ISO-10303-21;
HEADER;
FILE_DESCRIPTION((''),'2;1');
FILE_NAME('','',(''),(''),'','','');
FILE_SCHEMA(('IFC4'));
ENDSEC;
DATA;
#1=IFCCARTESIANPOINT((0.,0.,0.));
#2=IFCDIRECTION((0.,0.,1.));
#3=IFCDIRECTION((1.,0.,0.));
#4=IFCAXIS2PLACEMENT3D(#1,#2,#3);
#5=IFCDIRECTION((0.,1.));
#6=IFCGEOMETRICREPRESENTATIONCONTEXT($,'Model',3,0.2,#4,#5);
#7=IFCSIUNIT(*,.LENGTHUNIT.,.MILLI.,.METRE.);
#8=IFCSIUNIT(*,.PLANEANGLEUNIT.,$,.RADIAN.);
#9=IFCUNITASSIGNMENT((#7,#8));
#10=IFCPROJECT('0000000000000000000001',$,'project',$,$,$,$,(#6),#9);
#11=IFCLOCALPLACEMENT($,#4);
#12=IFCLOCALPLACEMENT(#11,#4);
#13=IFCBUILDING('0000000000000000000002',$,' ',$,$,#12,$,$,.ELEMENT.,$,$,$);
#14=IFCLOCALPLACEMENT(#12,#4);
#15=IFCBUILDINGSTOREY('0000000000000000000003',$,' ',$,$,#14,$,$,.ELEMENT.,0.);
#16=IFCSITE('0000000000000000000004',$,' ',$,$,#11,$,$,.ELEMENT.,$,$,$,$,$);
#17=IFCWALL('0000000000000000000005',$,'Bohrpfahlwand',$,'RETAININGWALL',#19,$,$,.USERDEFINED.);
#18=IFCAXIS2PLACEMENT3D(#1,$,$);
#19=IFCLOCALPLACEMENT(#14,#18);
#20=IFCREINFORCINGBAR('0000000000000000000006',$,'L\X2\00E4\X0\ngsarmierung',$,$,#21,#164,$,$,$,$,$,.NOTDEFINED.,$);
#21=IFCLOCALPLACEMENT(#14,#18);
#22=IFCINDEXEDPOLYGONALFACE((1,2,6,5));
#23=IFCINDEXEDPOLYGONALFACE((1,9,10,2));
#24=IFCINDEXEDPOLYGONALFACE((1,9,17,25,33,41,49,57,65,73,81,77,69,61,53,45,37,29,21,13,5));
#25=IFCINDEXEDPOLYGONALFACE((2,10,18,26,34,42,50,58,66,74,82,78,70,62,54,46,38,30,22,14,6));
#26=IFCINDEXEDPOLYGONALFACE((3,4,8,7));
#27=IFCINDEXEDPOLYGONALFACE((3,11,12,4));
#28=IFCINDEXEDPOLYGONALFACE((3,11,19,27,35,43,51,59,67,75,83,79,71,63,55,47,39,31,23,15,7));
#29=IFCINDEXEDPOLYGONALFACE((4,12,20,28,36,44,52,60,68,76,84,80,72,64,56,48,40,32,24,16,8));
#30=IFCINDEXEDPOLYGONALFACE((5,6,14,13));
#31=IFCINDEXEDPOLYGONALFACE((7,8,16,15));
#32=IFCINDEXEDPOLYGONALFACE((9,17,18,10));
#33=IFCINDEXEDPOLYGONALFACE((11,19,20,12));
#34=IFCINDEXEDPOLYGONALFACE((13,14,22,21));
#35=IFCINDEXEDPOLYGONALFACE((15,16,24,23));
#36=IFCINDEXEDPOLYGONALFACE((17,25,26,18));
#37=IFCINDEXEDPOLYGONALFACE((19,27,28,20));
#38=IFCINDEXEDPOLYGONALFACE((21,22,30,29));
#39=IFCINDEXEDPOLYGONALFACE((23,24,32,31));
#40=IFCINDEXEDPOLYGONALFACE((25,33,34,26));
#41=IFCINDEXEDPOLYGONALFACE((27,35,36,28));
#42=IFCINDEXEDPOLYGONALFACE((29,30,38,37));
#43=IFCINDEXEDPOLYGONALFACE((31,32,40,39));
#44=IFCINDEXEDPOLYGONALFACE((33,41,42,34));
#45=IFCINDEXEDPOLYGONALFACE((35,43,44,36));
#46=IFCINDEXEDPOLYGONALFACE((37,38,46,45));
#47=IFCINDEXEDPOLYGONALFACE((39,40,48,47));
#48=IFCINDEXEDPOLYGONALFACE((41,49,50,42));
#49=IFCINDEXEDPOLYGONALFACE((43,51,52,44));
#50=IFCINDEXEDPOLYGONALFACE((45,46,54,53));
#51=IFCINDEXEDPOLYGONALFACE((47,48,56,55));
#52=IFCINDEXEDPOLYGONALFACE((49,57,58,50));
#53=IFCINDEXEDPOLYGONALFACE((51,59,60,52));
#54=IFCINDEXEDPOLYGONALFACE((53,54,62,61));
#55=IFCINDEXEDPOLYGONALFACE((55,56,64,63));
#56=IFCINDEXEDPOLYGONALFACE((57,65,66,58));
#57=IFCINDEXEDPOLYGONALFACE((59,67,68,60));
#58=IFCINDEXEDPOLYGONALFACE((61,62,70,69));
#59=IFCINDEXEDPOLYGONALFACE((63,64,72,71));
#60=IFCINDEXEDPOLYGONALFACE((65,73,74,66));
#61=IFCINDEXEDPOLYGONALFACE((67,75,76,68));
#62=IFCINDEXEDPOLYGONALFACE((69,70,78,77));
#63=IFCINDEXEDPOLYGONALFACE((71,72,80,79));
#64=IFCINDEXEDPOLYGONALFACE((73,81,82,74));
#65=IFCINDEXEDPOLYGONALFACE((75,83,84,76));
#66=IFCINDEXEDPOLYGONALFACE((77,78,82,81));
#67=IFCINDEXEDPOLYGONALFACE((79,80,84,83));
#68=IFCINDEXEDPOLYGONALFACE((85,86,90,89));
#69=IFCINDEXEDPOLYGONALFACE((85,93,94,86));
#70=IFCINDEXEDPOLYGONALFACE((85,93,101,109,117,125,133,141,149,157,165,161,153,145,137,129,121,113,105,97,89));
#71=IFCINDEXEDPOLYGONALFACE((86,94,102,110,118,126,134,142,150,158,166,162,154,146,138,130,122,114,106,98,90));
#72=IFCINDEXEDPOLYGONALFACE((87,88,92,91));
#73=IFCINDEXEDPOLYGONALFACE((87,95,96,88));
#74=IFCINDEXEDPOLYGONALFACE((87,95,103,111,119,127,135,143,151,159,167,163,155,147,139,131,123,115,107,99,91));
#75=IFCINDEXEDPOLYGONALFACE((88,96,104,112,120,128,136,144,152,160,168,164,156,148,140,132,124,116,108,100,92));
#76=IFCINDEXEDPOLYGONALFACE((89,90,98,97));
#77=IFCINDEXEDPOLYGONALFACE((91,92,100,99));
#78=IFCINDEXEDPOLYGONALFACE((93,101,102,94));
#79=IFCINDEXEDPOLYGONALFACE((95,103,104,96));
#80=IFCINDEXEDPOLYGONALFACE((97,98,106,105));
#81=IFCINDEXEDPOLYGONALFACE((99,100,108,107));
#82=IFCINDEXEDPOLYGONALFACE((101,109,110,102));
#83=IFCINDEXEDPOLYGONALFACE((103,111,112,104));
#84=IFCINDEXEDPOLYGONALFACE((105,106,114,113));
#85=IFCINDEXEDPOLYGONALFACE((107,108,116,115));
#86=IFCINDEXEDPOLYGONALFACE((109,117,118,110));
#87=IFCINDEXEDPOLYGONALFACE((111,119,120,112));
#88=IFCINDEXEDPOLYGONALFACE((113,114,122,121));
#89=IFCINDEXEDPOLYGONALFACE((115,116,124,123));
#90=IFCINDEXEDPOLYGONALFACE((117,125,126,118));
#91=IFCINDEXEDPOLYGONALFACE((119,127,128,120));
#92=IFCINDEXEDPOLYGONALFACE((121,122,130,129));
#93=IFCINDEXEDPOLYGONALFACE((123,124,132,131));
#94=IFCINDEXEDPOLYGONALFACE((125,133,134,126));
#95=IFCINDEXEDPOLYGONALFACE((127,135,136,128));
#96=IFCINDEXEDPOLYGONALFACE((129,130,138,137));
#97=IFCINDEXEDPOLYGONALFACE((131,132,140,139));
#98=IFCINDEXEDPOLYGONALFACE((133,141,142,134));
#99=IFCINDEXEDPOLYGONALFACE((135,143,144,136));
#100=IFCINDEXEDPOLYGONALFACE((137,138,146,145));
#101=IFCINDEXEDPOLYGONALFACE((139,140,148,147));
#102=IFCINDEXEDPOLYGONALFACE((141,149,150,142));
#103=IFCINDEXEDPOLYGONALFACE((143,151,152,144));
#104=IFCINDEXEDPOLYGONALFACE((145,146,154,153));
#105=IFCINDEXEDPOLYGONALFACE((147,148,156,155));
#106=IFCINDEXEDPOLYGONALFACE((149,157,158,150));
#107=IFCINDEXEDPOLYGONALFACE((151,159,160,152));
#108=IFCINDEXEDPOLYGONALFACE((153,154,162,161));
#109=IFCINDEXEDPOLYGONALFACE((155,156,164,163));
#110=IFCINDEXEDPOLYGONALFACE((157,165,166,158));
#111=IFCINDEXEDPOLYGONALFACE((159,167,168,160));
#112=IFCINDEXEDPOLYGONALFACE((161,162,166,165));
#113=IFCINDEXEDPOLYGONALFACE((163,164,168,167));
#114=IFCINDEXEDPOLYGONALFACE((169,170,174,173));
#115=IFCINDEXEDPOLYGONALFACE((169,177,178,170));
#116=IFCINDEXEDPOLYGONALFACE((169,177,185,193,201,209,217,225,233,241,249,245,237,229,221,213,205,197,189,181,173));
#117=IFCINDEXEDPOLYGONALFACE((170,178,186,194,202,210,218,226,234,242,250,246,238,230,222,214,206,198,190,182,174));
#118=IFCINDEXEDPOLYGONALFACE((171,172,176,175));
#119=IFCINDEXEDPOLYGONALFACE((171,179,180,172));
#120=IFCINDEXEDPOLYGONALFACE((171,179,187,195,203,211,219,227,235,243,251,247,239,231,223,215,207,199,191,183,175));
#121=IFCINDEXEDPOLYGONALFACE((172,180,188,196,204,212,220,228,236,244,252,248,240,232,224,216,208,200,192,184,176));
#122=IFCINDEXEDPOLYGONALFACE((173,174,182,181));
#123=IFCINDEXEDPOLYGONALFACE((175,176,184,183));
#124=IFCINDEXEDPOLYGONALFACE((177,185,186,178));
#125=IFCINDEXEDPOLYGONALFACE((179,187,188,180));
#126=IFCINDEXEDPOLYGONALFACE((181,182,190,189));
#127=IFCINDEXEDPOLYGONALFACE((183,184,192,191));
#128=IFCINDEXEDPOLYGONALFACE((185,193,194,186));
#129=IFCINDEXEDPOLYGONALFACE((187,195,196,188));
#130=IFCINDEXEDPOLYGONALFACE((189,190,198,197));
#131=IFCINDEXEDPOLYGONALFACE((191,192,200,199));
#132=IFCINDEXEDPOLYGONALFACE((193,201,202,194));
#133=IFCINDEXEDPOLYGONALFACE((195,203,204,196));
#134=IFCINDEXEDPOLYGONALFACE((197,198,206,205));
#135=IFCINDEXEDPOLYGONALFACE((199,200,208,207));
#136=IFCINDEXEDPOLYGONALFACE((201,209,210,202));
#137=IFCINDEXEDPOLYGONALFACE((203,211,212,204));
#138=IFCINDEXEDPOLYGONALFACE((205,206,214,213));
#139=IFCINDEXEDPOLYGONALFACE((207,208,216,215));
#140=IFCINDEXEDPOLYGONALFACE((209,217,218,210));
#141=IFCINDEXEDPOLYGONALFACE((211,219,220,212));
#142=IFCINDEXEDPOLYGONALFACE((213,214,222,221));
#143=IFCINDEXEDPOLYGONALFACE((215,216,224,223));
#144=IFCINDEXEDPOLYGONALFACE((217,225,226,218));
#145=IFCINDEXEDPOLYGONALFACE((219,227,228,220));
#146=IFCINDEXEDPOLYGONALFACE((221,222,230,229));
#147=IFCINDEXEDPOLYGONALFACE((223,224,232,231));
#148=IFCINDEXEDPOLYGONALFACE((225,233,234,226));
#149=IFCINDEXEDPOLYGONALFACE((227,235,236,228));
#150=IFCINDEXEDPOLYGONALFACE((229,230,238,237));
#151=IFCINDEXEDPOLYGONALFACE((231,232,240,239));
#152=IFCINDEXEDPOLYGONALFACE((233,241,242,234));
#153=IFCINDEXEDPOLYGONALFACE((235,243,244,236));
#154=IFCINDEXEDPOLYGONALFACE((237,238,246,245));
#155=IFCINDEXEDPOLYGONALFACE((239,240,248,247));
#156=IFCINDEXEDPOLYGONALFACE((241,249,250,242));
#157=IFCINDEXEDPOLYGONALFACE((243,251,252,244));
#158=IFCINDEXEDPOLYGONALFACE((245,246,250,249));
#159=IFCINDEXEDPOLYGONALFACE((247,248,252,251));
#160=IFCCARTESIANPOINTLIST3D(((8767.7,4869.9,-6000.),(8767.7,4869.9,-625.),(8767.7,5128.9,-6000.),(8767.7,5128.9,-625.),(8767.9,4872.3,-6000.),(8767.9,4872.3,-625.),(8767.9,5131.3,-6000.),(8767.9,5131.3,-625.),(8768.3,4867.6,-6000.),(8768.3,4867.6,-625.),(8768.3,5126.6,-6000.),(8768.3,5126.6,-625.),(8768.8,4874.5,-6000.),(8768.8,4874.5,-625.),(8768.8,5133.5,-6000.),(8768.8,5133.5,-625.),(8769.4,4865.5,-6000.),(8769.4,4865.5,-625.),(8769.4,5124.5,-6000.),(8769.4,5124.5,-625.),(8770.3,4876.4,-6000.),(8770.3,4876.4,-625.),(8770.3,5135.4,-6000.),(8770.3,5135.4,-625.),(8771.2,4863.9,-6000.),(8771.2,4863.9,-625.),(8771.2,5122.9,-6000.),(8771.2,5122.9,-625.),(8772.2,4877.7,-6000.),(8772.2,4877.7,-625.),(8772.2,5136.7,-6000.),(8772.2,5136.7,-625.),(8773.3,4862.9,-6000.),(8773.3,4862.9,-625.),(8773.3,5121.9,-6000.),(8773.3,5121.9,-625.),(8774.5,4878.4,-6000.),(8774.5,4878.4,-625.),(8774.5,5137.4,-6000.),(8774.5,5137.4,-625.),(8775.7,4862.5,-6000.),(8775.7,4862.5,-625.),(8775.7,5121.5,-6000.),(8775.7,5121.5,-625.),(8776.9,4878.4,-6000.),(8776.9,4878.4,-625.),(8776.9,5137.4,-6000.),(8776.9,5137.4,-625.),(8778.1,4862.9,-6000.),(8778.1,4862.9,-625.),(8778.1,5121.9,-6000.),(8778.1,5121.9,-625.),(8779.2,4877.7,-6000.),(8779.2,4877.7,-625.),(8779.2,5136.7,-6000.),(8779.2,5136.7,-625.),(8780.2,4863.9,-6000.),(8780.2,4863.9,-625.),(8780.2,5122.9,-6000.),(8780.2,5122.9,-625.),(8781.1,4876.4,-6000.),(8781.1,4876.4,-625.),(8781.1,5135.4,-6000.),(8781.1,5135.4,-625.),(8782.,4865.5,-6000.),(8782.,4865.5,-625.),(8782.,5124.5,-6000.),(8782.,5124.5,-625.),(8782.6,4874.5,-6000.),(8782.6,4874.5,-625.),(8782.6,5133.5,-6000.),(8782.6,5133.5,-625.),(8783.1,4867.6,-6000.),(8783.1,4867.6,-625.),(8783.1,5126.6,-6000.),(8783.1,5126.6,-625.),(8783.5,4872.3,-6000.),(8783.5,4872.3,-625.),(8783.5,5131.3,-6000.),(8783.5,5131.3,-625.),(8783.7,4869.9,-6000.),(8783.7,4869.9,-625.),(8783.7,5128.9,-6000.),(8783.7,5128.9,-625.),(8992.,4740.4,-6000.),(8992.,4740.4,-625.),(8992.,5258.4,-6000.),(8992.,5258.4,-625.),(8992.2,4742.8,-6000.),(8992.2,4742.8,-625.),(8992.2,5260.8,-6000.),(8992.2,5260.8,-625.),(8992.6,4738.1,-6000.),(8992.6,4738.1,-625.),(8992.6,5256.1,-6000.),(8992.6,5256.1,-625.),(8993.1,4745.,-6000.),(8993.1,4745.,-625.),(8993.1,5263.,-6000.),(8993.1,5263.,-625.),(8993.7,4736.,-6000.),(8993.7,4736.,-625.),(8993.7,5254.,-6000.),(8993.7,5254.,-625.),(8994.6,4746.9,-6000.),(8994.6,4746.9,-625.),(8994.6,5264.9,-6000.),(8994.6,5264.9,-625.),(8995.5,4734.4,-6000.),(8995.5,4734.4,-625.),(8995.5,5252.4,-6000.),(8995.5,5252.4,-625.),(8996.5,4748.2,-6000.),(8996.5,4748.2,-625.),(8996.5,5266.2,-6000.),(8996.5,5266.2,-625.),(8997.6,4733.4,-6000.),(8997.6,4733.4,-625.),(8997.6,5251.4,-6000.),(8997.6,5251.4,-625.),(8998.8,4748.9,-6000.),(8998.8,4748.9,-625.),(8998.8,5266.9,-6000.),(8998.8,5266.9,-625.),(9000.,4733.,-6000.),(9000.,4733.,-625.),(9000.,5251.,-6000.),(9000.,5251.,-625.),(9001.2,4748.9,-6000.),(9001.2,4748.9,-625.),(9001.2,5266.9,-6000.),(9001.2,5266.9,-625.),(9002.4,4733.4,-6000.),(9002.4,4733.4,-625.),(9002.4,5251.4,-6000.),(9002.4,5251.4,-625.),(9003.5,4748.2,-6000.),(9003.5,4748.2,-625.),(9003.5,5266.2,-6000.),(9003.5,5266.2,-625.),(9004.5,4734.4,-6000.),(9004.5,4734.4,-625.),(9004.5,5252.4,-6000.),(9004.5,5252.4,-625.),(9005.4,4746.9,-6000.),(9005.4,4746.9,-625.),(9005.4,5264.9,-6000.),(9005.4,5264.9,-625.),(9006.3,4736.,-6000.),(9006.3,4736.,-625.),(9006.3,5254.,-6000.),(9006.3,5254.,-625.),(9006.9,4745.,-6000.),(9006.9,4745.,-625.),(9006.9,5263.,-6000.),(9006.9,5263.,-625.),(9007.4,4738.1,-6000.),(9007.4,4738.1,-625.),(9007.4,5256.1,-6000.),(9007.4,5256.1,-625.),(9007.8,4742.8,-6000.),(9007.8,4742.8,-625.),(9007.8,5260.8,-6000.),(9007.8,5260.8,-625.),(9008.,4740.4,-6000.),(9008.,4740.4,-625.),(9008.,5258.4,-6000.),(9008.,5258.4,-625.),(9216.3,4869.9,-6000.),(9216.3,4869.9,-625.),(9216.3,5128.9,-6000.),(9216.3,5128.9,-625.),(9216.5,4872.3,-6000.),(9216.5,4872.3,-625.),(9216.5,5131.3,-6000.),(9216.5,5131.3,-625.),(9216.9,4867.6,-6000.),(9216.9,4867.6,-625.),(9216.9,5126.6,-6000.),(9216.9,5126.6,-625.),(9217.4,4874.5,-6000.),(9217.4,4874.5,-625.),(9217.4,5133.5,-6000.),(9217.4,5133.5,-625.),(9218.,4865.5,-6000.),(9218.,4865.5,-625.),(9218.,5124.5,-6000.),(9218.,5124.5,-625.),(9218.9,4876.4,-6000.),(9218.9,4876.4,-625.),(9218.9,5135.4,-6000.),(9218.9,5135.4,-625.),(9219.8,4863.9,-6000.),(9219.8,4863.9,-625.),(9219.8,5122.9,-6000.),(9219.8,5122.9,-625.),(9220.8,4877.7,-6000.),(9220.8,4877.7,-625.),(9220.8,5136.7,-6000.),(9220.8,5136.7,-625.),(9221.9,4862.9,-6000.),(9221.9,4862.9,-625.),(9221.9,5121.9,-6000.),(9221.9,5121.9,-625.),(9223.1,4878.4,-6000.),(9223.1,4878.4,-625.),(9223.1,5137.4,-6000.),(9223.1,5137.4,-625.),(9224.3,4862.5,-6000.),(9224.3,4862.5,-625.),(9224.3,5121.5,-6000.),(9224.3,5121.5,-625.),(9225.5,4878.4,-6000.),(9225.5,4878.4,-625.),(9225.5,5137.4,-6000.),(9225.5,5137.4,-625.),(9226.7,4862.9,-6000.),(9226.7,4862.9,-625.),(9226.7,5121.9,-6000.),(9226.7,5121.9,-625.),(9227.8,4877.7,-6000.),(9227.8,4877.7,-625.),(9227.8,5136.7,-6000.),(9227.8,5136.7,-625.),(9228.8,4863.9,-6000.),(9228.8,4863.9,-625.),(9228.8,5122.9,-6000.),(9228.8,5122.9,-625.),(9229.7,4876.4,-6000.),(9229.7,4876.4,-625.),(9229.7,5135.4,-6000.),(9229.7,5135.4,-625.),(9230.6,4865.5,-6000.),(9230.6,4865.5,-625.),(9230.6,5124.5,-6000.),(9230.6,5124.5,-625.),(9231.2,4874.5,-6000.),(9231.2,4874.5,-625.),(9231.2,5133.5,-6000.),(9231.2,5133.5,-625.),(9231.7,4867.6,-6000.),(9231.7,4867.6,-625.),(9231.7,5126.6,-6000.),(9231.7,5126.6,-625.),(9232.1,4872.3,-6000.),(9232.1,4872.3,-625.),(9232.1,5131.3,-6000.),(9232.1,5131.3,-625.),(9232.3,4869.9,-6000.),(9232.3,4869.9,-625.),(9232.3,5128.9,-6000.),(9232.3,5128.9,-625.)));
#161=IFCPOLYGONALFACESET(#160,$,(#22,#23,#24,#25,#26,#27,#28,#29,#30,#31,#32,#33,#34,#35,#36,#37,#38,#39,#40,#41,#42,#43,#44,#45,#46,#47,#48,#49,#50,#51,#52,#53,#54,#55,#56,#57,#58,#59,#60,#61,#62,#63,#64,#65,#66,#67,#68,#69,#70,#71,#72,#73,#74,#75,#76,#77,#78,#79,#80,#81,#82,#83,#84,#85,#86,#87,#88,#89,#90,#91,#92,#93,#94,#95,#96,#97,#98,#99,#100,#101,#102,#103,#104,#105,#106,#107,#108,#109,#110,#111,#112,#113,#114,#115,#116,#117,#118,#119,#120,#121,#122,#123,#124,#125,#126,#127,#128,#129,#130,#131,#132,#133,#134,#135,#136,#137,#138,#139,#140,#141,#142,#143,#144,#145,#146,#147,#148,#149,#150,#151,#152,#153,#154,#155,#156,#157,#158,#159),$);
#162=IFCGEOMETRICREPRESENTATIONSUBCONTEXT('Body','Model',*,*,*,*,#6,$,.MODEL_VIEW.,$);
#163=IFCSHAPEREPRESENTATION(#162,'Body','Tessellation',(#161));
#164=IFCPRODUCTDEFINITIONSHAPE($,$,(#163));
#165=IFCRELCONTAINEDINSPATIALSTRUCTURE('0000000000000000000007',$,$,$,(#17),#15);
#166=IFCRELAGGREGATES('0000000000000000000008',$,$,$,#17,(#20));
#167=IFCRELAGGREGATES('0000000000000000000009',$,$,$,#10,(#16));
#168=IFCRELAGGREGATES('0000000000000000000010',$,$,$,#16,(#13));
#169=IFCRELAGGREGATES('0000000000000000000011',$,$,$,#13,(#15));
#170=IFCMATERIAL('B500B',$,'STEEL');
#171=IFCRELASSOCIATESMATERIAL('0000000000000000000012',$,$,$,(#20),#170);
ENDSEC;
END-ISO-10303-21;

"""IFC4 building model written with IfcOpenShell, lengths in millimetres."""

from ifc_helpers import new_model, entity, si_unit, direction, frame, origin_with_axes, place, context, subcontext, project, spatial, source, transform, mapped, material, element, aggregate, save


model = new_model("IFC4")

# Units and contexts
model_context = context("Model", 3, precision=0.2, world=origin_with_axes(), true_north=direction((0.0, 1.0)))
body_context = subcontext(model_context, "Body", "Model", "MODEL_VIEW")
ifc_project = project(units=[si_unit("LENGTHUNIT", "METRE", prefix="MILLI"), si_unit("PLANEANGLEUNIT", "RADIAN")], contexts=[model_context])

# Site, building, storey
site_placement = place(None, origin_with_axes())
site = spatial("IfcSite", under=ifc_project, at=site_placement, Name=" ", CompositionType="ELEMENT")
building_placement = place(site_placement, origin_with_axes())
building = spatial("IfcBuilding", under=site, at=building_placement, Name=" ", CompositionType="ELEMENT")
storey_placement = place(building_placement, origin_with_axes())
storey = spatial("IfcBuildingStorey", under=building, at=storey_placement, Name=" ", CompositionType="ELEMENT", Elevation=0.0)

# Wall, reinforcing bar
wall_1_placement = place(storey_placement, frame((9000.0, 6000.0, -6000.0), z_axis=(-1.0, 0.0, 0.0), x_axis=(0.0, 0.0, 1.0)))
wall_1 = element("IfcWall", 1, at=wall_1_placement, inside=storey, Name="Bohrpfahlwand", ObjectType="RETAININGWALL", PredefinedType="USERDEFINED")
ifc_material_1 = material(Name="B500B", Category="STEEL")
shared_shape_1 = source(origin_with_axes(), body_context, "Body", "AdvancedSweptSolid", [
    entity("IfcSweptDiskSolid", entity("IfcIndexedPolyCurve", entity("IfcCartesianPointList3D", [[0.0, 0.0, 0.0], [5375.0, 0.0, 0.0]]), [entity("IfcLineIndex", [1, 2])]), 8.0),
])
reinforcing_bar_1_placement = place(wall_1_placement, frame((0.0, -741.0, 0.0), z_axis=(0.0, 0.5, 0.866025), x_axis=(1.0, 0.0, 0.0)))
reinforcing_bar_1 = element("IfcReinforcingBar", 2, at=reinforcing_bar_1_placement, material=ifc_material_1, Name="Längsarmierung", PredefinedType="NOTDEFINED", context=body_context, shape_type="MappedRepresentation", body=[
    mapped(shared_shape_1, transform((0.0, 0.0, 0.0))),
    mapped(shared_shape_1, transform((0.0, -224.3, 129.5))),
    mapped(shared_shape_1, transform((0.0, -448.6, 0.0))),
    mapped(shared_shape_1, transform((0.0, -448.6, -259.0))),
    mapped(shared_shape_1, transform((0.0, -224.3, -388.5))),
    mapped(shared_shape_1, transform((0.0, 0.0, -259.0))),
])

aggregate(wall_1, [reinforcing_bar_1])

save(model, "model.ifc")
